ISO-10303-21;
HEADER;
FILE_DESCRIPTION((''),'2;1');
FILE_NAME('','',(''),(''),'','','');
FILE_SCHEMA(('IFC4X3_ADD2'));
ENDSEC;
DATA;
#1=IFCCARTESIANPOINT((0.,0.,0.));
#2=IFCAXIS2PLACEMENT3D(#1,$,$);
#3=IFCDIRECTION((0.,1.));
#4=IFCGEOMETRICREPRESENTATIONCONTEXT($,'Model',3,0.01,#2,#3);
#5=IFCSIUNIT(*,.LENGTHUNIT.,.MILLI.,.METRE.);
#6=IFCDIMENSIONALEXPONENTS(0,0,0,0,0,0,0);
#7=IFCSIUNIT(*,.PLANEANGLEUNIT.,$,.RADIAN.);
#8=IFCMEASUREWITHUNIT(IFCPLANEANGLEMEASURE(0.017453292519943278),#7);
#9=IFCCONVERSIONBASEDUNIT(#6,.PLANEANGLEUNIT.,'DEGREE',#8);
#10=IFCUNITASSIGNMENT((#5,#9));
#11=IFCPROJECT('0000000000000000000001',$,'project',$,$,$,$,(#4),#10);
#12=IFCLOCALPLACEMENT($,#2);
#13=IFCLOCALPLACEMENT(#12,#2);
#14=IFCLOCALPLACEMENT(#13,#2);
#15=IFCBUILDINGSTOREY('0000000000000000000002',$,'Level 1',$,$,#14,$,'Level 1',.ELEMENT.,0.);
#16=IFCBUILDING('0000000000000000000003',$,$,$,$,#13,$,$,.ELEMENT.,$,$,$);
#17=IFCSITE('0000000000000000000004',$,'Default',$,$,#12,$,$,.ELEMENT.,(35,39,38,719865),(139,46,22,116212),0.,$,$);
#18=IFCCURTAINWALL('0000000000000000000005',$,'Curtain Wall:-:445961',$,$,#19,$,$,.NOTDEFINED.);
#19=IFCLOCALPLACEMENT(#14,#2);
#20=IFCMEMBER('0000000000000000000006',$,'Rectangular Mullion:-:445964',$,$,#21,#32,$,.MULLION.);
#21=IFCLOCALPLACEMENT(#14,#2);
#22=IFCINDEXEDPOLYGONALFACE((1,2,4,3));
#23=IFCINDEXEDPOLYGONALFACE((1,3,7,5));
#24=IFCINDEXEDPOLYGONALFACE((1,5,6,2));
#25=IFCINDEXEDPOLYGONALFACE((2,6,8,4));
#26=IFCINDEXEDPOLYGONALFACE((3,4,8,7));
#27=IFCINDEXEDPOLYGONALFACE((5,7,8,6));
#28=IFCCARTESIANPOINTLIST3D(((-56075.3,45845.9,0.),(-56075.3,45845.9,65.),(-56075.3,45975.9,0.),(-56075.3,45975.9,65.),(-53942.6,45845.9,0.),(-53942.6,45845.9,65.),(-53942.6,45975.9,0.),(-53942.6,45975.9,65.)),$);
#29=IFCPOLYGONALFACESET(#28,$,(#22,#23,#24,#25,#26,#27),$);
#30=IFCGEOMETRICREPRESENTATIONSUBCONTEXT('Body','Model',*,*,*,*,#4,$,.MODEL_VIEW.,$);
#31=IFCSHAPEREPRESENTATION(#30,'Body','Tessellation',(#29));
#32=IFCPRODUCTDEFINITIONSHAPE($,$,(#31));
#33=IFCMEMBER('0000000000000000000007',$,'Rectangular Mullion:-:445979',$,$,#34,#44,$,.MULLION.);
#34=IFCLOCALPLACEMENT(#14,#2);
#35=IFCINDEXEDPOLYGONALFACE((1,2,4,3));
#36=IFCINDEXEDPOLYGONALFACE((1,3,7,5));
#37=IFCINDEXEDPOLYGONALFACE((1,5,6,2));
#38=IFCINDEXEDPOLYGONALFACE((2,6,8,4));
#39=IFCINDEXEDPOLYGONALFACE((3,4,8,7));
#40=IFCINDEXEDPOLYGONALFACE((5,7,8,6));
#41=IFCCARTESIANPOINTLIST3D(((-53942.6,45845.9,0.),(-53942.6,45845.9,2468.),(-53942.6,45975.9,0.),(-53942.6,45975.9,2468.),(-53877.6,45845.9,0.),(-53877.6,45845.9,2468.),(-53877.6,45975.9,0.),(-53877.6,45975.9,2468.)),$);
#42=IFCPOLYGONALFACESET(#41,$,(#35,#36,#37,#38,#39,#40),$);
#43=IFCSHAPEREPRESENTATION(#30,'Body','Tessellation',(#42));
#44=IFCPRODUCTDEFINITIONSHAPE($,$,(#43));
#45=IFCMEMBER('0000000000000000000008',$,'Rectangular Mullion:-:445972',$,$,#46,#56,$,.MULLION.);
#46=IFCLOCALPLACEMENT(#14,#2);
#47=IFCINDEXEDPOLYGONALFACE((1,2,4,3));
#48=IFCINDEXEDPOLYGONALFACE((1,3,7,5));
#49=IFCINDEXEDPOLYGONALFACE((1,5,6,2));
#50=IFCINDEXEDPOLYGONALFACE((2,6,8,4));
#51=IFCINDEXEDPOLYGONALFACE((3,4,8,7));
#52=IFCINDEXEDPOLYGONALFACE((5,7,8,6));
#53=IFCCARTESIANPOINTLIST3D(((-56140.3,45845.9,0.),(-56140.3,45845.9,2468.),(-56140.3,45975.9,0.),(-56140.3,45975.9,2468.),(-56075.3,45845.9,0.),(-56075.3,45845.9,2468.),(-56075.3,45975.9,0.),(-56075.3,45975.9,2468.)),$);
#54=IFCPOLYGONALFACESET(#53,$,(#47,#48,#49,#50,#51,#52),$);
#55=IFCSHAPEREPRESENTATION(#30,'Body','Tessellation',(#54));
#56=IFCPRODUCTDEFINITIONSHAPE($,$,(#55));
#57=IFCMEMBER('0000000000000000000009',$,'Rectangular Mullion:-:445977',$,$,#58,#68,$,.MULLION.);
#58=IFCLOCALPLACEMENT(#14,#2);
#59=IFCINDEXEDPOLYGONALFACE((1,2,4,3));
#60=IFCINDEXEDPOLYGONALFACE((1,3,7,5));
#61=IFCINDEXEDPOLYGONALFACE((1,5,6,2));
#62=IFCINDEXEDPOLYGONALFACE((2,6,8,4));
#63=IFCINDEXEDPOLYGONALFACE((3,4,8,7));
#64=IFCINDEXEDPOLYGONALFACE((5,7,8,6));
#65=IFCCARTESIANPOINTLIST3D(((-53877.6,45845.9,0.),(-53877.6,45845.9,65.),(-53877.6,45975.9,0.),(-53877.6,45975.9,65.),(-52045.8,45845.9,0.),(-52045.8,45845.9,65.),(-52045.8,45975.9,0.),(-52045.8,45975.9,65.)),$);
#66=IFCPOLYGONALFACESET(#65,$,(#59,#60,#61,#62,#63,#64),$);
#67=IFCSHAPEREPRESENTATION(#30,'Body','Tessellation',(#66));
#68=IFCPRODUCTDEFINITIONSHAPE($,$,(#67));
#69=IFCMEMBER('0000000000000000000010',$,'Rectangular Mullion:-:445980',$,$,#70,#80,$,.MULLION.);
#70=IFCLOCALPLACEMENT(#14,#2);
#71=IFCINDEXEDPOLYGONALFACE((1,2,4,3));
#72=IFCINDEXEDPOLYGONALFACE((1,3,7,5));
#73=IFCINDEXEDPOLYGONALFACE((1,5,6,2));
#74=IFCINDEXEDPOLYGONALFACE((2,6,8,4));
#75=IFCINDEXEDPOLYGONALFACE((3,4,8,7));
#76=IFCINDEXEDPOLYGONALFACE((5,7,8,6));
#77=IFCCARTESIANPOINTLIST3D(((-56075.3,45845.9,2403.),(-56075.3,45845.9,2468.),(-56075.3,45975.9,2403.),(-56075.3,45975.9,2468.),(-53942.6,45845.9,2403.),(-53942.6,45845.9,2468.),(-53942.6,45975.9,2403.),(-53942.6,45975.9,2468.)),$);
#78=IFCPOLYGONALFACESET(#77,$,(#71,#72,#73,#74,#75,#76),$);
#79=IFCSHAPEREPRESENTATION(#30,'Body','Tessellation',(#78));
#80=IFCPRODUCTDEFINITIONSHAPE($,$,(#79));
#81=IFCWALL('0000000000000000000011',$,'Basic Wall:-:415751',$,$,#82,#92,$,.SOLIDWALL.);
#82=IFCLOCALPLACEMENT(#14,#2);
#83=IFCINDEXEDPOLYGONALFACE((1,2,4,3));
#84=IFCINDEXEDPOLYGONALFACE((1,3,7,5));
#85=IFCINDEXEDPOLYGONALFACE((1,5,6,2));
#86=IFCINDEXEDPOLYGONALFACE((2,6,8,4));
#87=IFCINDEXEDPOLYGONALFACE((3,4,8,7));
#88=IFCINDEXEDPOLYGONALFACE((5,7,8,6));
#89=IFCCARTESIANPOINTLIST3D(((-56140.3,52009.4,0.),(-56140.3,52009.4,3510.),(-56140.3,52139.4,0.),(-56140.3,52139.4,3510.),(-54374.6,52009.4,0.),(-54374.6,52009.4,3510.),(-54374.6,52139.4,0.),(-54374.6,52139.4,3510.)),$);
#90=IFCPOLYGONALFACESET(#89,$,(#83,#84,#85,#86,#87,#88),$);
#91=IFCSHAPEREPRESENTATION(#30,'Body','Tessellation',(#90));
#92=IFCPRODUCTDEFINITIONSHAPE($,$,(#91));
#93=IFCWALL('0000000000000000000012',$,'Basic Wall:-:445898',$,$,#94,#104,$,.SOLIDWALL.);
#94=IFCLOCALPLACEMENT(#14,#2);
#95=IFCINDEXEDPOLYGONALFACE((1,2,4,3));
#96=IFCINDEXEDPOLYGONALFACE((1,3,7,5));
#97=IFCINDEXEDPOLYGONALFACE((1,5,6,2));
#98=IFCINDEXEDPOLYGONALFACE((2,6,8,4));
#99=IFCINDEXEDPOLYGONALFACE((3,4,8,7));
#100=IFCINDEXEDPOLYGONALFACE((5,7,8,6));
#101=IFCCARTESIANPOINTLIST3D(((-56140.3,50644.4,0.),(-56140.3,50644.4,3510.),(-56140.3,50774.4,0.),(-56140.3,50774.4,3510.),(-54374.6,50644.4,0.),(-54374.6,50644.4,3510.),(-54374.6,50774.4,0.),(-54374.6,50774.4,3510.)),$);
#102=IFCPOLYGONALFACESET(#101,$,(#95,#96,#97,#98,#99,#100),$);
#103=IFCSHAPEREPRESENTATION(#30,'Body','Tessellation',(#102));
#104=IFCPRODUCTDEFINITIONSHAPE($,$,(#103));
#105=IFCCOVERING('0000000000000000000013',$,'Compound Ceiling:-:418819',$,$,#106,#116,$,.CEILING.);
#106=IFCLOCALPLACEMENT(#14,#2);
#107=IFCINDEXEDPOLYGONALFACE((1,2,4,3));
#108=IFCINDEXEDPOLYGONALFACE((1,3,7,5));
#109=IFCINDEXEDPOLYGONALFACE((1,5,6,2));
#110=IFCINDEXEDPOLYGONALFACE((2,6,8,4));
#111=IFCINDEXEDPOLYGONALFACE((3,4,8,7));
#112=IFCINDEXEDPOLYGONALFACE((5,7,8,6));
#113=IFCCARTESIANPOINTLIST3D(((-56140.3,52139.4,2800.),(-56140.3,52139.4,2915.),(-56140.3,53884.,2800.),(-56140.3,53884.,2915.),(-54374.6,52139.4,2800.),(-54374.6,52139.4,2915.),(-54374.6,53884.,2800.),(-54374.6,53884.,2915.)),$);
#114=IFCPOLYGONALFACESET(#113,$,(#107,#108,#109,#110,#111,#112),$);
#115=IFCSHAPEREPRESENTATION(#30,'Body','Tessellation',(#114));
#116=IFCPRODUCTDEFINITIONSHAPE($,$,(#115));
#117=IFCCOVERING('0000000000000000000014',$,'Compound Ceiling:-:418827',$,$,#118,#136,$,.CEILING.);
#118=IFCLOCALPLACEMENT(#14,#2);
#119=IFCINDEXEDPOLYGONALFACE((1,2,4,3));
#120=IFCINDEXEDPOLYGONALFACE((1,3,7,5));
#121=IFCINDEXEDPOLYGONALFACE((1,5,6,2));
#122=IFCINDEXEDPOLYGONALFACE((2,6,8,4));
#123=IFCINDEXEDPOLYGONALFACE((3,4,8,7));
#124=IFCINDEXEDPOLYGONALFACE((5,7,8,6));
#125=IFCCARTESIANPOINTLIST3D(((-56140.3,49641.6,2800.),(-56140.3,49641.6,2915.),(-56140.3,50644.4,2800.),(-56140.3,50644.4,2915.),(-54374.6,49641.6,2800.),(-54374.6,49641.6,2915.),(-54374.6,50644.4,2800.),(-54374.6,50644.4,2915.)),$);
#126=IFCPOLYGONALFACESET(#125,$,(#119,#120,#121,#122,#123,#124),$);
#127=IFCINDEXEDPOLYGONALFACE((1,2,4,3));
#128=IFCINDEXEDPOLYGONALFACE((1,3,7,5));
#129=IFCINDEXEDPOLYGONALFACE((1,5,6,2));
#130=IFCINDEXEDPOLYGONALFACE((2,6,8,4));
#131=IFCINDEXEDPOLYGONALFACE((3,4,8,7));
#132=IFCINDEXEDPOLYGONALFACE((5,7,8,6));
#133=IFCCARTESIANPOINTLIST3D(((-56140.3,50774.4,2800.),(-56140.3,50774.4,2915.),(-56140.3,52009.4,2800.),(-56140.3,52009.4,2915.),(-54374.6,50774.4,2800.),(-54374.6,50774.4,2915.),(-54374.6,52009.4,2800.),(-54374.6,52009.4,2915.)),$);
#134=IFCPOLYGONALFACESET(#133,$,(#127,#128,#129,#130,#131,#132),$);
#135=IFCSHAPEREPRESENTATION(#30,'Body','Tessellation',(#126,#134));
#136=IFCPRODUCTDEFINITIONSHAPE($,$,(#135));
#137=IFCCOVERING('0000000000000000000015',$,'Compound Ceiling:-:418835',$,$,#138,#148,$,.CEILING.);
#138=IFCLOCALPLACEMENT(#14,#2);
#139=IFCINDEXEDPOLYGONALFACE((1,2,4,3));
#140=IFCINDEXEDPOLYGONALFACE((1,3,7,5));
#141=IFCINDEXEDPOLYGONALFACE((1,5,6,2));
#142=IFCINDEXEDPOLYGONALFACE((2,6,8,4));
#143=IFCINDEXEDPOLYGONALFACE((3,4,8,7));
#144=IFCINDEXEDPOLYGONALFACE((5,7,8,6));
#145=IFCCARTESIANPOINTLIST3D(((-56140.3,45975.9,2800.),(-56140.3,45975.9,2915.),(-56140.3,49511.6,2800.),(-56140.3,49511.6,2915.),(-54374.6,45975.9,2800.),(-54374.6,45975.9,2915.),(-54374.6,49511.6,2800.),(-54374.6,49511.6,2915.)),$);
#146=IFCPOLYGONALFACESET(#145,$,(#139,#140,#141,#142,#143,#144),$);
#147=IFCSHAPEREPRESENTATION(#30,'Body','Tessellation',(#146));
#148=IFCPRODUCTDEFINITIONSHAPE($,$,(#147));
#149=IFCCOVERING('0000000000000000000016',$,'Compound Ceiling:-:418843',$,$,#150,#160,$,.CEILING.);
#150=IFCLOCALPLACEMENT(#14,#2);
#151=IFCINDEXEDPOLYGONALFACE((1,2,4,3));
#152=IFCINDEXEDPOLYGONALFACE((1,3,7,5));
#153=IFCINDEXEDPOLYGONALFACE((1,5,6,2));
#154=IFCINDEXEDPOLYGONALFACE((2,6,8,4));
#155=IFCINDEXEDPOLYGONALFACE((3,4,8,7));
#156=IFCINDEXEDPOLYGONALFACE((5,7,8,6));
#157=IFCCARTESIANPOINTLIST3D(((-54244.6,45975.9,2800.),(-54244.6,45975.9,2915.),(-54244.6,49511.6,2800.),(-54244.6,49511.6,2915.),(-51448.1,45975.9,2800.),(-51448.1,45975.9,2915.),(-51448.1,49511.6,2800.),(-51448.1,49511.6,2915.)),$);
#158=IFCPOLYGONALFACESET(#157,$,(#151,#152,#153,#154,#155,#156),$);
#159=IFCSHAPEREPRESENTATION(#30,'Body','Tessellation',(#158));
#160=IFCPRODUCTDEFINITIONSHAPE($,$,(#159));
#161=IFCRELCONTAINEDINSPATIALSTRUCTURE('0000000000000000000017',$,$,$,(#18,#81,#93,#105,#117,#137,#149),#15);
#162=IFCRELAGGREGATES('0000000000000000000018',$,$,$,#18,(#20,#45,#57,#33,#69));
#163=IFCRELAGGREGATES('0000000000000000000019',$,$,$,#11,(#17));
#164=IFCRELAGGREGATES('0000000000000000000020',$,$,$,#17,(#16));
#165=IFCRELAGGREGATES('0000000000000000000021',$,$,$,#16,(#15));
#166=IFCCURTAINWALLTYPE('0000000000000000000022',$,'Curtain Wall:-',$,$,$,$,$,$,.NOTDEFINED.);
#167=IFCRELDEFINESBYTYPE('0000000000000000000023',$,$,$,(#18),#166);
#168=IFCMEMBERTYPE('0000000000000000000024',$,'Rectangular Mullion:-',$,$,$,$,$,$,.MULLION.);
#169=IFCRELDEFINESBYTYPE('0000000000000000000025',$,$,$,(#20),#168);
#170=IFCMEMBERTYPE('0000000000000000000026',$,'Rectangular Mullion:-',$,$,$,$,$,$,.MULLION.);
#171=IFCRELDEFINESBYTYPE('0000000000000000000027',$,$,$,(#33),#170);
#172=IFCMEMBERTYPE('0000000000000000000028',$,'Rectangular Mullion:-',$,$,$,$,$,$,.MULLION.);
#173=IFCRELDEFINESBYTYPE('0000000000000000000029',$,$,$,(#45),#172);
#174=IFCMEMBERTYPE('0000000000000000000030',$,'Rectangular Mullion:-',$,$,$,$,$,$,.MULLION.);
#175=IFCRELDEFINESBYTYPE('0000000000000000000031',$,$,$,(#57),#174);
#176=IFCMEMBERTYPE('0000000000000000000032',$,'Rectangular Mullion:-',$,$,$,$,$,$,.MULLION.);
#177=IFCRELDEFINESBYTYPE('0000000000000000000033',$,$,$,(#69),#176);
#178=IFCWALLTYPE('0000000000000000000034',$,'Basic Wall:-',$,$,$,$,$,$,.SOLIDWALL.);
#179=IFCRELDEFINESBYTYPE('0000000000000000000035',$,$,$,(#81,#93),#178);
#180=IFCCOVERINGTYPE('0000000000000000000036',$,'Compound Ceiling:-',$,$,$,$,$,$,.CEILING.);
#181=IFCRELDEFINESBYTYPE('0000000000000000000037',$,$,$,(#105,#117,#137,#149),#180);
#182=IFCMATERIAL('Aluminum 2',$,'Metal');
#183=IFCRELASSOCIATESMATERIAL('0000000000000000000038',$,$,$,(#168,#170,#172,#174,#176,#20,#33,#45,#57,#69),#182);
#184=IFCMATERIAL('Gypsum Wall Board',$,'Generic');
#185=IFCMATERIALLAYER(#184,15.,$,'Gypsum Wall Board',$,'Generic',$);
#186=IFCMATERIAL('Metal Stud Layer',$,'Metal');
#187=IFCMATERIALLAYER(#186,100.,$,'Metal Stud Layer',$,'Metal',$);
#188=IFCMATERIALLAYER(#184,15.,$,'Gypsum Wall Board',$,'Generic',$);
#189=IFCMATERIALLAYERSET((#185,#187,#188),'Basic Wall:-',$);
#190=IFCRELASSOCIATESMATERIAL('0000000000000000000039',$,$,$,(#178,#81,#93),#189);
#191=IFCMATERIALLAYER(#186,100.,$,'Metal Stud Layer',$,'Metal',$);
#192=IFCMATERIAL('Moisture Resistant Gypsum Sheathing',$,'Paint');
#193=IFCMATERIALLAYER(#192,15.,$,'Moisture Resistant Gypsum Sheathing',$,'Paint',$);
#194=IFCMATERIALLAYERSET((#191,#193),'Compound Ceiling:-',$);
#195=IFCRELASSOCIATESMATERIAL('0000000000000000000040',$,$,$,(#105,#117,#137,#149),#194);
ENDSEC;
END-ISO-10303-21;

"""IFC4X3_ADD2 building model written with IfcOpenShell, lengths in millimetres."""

from ifc_helpers import new_model, entity, si_unit, converted_unit, direction, frame, frame_2d, origin, origin_2d_with_axis, place, context, subcontext, project, spatial, rectangle, extrude, source, transform, mapped, material, layer, layer_set, layer_usage, material_profile, profile_set, profile_usage, type_object, type_shapes, element, aggregate, save


model = new_model("IFC4X3_ADD2")

# Units and contexts
model_context = context("Model", 3, precision=0.01, world=origin(), true_north=direction((0.0, 1.0)))
body_context = subcontext(model_context, "Body", "Model", "MODEL_VIEW")
ifc_project = project(units=[si_unit("LENGTHUNIT", "METRE", prefix="MILLI"), converted_unit("PLANEANGLEUNIT", "DEGREE", entity("IfcPlaneAngleMeasure", 0.017453292519943278), si_unit("PLANEANGLEUNIT", "RADIAN"), dimensions=[0, 0, 0, 0, 0, 0, 0])], contexts=[model_context])

# Site, building, storey
site_placement = place(None, origin())
site = spatial("IfcSite", under=ifc_project, at=site_placement, Name="Default", CompositionType="ELEMENT", RefLatitude=(35, 39, 38, 719865), RefLongitude=(139, 46, 22, 116212), RefElevation=0.0)
building_placement = place(site_placement, origin())
building = spatial("IfcBuilding", under=site, at=building_placement, CompositionType="ELEMENT")
storey_placement = place(building_placement, origin())
storey = spatial("IfcBuildingStorey", under=building, at=storey_placement, Name="Level 1", LongName="Level 1", CompositionType="ELEMENT", Elevation=0.0)

# Curtain wall, members
curtain_wall_type = type_object("IfcCurtainWallType", Name="Curtain Wall:-", PredefinedType="NOTDEFINED")
curtain_wall_placement = place(storey_placement, origin())
curtain_wall = element("IfcCurtainWall", 1, at=curtain_wall_placement, inside=storey, type_object=curtain_wall_type, Name="Curtain Wall:-:445961", PredefinedType="NOTDEFINED")
ifc_material_1 = material(Name="Aluminum 2", Category="Metal")
ifc_material_profile = material_profile(ifc_material_1, rectangle(XDim=65.0, YDim=130.0, at=origin_2d_with_axis()), Name="-")
ifc_profile_set = profile_set([ifc_material_profile], Name="-")
ifc_profile_usage = profile_usage(ifc_profile_set)
member_type_1 = type_object("IfcMemberType", Name="Rectangular Mullion:-", PredefinedType="MULLION", material=ifc_profile_set)
shared_shape_1 = source(origin(), body_context, "Body", "SweptSolid", [
    extrude(rectangle(XDim=65.0, YDim=130.0, at=origin_2d_with_axis()), frame((-32.5, 0.0, -2132.6), z_axis=(0.0, 0.0, 1.0), x_axis=(-1.0, 0.0, 0.0)), (0.0, 0.0, 1.0), 2132.6),
])
type_shapes(member_type_1, [shared_shape_1])
member_1_placement = place(curtain_wall_placement, frame((-56075.3, 45910.9, 0.0), z_axis=(-1.0, 0.0, 0.0), x_axis=(0.0, 0.0, -1.0)))
member_1 = element("IfcMember", 2, at=member_1_placement, type_object=member_type_1, material=ifc_profile_usage, Name="Rectangular Mullion:-:445964", PredefinedType="MULLION", context=body_context, shape_type="MappedRepresentation", body=[
    mapped(shared_shape_1, transform((0.0, 0.0, 0.0), scale=1.0)),
])
member_type_2 = type_object("IfcMemberType", Name="Rectangular Mullion:-", PredefinedType="MULLION", material=ifc_profile_set)
shared_shape_2 = source(origin(), body_context, "Body", "SweptSolid", [
    extrude(rectangle(XDim=65.0, YDim=130.0, at=frame_2d((0.0, 0.0), x_axis=(1.0, 0.0))), frame((0.0, 0.0, -2468.0), z_axis=(0.0, 0.0, 1.0), x_axis=(-1.0, 0.0, 0.0)), (0.0, 0.0, 1.0), 2468.0),
])
type_shapes(member_type_2, [shared_shape_2])
member_2_placement = place(curtain_wall_placement, frame((-53910.1, 45910.9, 0.0), z_axis=(0.0, 0.0, -1.0), x_axis=(1.0, 0.0, 0.0)))
member_2 = element("IfcMember", 3, at=member_2_placement, type_object=member_type_2, material=ifc_profile_usage, Name="Rectangular Mullion:-:445979", PredefinedType="MULLION", context=body_context, shape_type="MappedRepresentation", body=[
    mapped(shared_shape_2, transform((0.0, 0.0, 0.0), scale=1.0)),
])
member_type_3 = type_object("IfcMemberType", Name="Rectangular Mullion:-", PredefinedType="MULLION", material=ifc_profile_set)
shared_shape_3 = source(origin(), body_context, "Body", "SweptSolid", [
    extrude(rectangle(XDim=65.0, YDim=130.0, at=frame_2d((0.0, 0.0), x_axis=(1.0, 0.0))), frame((-32.5, 0.0, -2468.0), z_axis=(0.0, 0.0, 1.0), x_axis=(-1.0, 0.0, 0.0)), (0.0, 0.0, 1.0), 2468.0),
])
type_shapes(member_type_3, [shared_shape_3])
member_3_placement = place(curtain_wall_placement, frame((-56140.3, 45910.9, 2468.0), z_axis=(0.0, 0.0, 1.0), x_axis=(-1.0, 0.0, 0.0)))
member_3 = element("IfcMember", 4, at=member_3_placement, type_object=member_type_3, material=ifc_profile_usage, Name="Rectangular Mullion:-:445972", PredefinedType="MULLION", context=body_context, shape_type="MappedRepresentation", body=[
    mapped(shared_shape_3, transform((0.0, 0.0, 0.0), scale=1.0)),
])
member_type_4 = type_object("IfcMemberType", Name="Rectangular Mullion:-", PredefinedType="MULLION", material=ifc_profile_set)
shared_shape_4 = source(origin(), body_context, "Body", "SweptSolid", [
    extrude(rectangle(XDim=65.0, YDim=130.0, at=frame_2d((0.0, 0.0), x_axis=(1.0, 0.0))), frame((-32.5, 0.0, -1831.9), z_axis=(0.0, 0.0, 1.0), x_axis=(-1.0, 0.0, 0.0)), (0.0, 0.0, 1.0), 1831.9),
])
type_shapes(member_type_4, [shared_shape_4])
member_4_placement = place(curtain_wall_placement, frame((-53877.6, 45910.9, 0.0), z_axis=(-1.0, 0.0, 0.0), x_axis=(0.0, 0.0, -1.0)))
member_4 = element("IfcMember", 5, at=member_4_placement, type_object=member_type_4, material=ifc_profile_usage, Name="Rectangular Mullion:-:445977", PredefinedType="MULLION", context=body_context, shape_type="MappedRepresentation", body=[
    mapped(shared_shape_4, transform((0.0, 0.0, 0.0), scale=1.0)),
])
member_type_5 = type_object("IfcMemberType", Name="Rectangular Mullion:-", PredefinedType="MULLION", material=ifc_profile_set)
shared_shape_5 = source(origin(), body_context, "Body", "SweptSolid", [
    extrude(rectangle(XDim=65.0, YDim=130.0, at=origin_2d_with_axis()), frame((0.0, 0.0, -2132.6), z_axis=(0.0, 0.0, 1.0), x_axis=(-1.0, 0.0, 0.0)), (0.0, 0.0, 1.0), 2132.6),
])
type_shapes(member_type_5, [shared_shape_5])
member_5_placement = place(curtain_wall_placement, frame((-53942.6, 45910.9, 2435.5), z_axis=(1.0, 0.0, 0.0), x_axis=(0.0, 0.0, 1.0)))
member_5 = element("IfcMember", 6, at=member_5_placement, type_object=member_type_5, material=ifc_profile_usage, Name="Rectangular Mullion:-:445980", PredefinedType="MULLION", context=body_context, shape_type="MappedRepresentation", body=[
    mapped(shared_shape_5, transform((0.0, 0.0, 0.0), scale=1.0)),
])
aggregate(curtain_wall, [member_1, member_3, member_4, member_2, member_5])

# Shared definitions
ifc_material_2 = material(Name="Gypsum Wall Board", Category="Generic")
ifc_layer_1 = layer(ifc_material_2, 15.0, Name="Gypsum Wall Board", Category="Generic")
ifc_material_3 = material(Name="Metal Stud Layer", Category="Metal")
ifc_layer_2 = layer(ifc_material_3, 100.0, Name="Metal Stud Layer", Category="Metal")
ifc_layer_3 = layer(ifc_material_2, 15.0, Name="Gypsum Wall Board", Category="Generic")
ifc_layer_set_1 = layer_set([ifc_layer_1, ifc_layer_2, ifc_layer_3], Name="Basic Wall:-")
wall_type = type_object("IfcWallType", Name="Basic Wall:-", PredefinedType="SOLIDWALL", material=ifc_layer_set_1)

# Walls
wall_1_placement = place(storey_placement, frame((-54374.6, 52074.4, 0.0), z_axis=(0.0, 0.0, 1.0), x_axis=(-1.0, 0.0, 0.0)))
element("IfcWall", 7, at=wall_1_placement, inside=storey, type_object=wall_type, material=ifc_layer_set_1, Name="Basic Wall:-:415751", PredefinedType="SOLIDWALL", context=body_context, shape_type="SweptSolid", body=[
    extrude(rectangle(XDim=1765.7, YDim=130.0, at=frame_2d((882.9, 0.0), x_axis=(-1.0, 0.0))), origin(), (0.0, 0.0, 1.0), 3510.0),
])
wall_2_placement = place(storey_placement, frame((-54374.6, 50709.4, 0.0), z_axis=(0.0, 0.0, 1.0), x_axis=(-1.0, 0.0, 0.0)))
element("IfcWall", 8, at=wall_2_placement, inside=storey, type_object=wall_type, material=ifc_layer_set_1, Name="Basic Wall:-:445898", PredefinedType="SOLIDWALL", context=body_context, shape_type="SweptSolid", body=[
    extrude(rectangle(XDim=1765.7, YDim=130.0, at=frame_2d((882.9, 0.0), x_axis=(-1.0, 0.0))), origin(), (0.0, 0.0, 1.0), 3510.0),
])

# Coverings
ifc_layer_4 = layer(ifc_material_3, 100.0, Name="Metal Stud Layer", Category="Metal")
ifc_material_4 = material(Name="Moisture Resistant Gypsum Sheathing", Category="Paint")
ifc_layer_5 = layer(ifc_material_4, 15.0, Name="Moisture Resistant Gypsum Sheathing", Category="Paint")
ifc_layer_set_2 = layer_set([ifc_layer_4, ifc_layer_5], Name="Compound Ceiling:-")
covering_type = type_object("IfcCoveringType", Name="Compound Ceiling:-", PredefinedType="CEILING")
ifc_layer_usage_1 = layer_usage(ifc_layer_set_2, "AXIS3", "NEGATIVE", 0.0)
covering_1_placement = place(storey_placement, frame((-56140.3, 52139.4, 2800.0)))
element("IfcCovering", 9, at=covering_1_placement, inside=storey, type_object=covering_type, material=ifc_layer_usage_1, Name="Compound Ceiling:-:418819", PredefinedType="CEILING", context=body_context, shape_type="SweptSolid", body=[
    extrude(rectangle(XDim=1744.7, YDim=1765.7, at=frame_2d((0.0, 0.0), x_axis=(1.0, 0.0))), frame((882.9, 872.3, 0.0), z_axis=(0.0, 0.0, 1.0), x_axis=(0.0, 1.0, 0.0)), (0.0, 0.0, 1.0), 115.0),
])
ifc_layer_usage_2 = layer_usage(ifc_layer_set_2, "AXIS3", "NEGATIVE", 0.0)
covering_2_placement = place(storey_placement, frame((-56140.3, 49641.6, 2800.0)))
element("IfcCovering", 10, at=covering_2_placement, inside=storey, type_object=covering_type, material=ifc_layer_usage_2, Name="Compound Ceiling:-:418827", PredefinedType="CEILING", context=body_context, shape_type="SweptSolid", body=[
    extrude(rectangle(XDim=1002.9, YDim=1765.7, at=frame_2d((0.0, 0.0), x_axis=(1.0, 0.0))), frame((882.9, 501.4, 0.0), z_axis=(0.0, 0.0, 1.0), x_axis=(0.0, 1.0, 0.0)), (0.0, 0.0, 1.0), 115.0),
    extrude(rectangle(XDim=1234.9, YDim=1765.7, at=origin_2d_with_axis()), frame((882.9, 1750.3, 0.0), z_axis=(0.0, 0.0, 1.0), x_axis=(0.0, -1.0, 0.0)), (0.0, 0.0, 1.0), 115.0),
])
ifc_layer_usage_3 = layer_usage(ifc_layer_set_2, "AXIS3", "NEGATIVE", 0.0)
covering_3_placement = place(storey_placement, frame((-56140.3, 45975.9, 2800.0)))
element("IfcCovering", 11, at=covering_3_placement, inside=storey, type_object=covering_type, material=ifc_layer_usage_3, Name="Compound Ceiling:-:418835", PredefinedType="CEILING", context=body_context, shape_type="SweptSolid", body=[
    extrude(rectangle(XDim=3535.6, YDim=1765.7, at=frame_2d((0.0, 0.0), x_axis=(1.0, 0.0))), frame((882.9, 1767.8, 0.0), z_axis=(0.0, 0.0, 1.0), x_axis=(0.0, -1.0, 0.0)), (0.0, 0.0, 1.0), 115.0),
])
ifc_layer_usage_4 = layer_usage(ifc_layer_set_2, "AXIS3", "NEGATIVE", 0.0)
covering_4_placement = place(storey_placement, frame((-54244.6, 45975.9, 2800.0)))
element("IfcCovering", 12, at=covering_4_placement, inside=storey, type_object=covering_type, material=ifc_layer_usage_4, Name="Compound Ceiling:-:418843", PredefinedType="CEILING", context=body_context, shape_type="SweptSolid", body=[
    extrude(rectangle(XDim=2796.4, YDim=3535.6, at=frame_2d((0.0, 0.0), x_axis=(1.0, 0.0))), frame((1398.2, 1767.8, 0.0)), (0.0, 0.0, 1.0), 115.0),
])

save(model, "model.ifc")
